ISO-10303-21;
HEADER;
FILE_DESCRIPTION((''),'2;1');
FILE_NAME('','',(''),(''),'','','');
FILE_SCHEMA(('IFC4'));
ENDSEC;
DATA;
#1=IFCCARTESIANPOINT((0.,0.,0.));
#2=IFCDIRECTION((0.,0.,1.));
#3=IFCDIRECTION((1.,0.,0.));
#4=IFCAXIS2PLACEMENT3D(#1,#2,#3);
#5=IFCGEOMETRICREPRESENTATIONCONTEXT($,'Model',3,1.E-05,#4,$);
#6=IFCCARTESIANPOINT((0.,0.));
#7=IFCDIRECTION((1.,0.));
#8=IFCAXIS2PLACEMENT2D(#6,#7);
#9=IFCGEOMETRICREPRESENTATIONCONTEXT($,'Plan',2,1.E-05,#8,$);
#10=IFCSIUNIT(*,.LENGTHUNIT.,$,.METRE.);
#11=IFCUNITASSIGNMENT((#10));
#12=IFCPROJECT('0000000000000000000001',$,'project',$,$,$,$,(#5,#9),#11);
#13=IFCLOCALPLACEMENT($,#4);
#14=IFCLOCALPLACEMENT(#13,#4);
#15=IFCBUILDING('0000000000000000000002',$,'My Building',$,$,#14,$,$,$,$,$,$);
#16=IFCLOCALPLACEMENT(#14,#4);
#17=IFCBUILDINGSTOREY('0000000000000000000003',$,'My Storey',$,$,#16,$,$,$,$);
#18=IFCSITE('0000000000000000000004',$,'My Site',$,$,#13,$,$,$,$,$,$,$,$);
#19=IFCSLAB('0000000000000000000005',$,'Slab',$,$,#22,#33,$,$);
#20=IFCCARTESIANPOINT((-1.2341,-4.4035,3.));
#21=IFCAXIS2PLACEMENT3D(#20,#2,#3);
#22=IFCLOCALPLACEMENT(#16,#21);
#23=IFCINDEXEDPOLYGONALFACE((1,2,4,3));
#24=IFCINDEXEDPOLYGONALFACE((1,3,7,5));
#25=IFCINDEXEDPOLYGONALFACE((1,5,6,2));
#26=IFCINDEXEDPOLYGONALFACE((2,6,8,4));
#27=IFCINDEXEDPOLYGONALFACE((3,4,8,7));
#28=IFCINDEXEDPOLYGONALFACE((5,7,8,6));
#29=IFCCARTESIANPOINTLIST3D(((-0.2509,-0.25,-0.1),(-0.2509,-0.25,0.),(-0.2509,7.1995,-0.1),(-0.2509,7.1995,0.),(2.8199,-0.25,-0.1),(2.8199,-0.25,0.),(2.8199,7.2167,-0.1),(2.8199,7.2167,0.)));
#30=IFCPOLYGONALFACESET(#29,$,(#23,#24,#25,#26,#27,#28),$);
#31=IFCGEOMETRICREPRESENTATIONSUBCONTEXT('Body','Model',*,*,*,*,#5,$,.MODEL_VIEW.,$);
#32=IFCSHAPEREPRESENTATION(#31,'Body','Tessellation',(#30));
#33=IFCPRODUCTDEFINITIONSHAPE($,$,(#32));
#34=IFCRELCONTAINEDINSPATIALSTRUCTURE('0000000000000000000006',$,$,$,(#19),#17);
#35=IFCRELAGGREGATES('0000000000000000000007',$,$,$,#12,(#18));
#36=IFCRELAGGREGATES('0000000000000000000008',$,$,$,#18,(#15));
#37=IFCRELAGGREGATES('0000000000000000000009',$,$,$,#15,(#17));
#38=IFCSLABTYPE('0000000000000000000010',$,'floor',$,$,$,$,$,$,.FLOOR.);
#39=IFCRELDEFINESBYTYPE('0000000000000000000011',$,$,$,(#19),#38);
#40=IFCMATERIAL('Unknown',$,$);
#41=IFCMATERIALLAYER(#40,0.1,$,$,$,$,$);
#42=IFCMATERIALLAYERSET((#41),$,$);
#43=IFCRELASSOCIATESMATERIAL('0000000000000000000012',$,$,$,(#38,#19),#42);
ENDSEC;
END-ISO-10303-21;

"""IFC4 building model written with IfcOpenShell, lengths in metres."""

from ifc_helpers import new_model, si_unit, frame, origin_with_axes, origin_2d_with_axis, place, context, subcontext, project, spatial, indexed_curve, outline, extrude, material, layer, layer_set, layer_usage, type_object, element, save


model = new_model("IFC4")

# Units and contexts
model_context = context("Model", 3, precision=1e-05, world=origin_with_axes())
plan_context = context("Plan", 2, precision=1e-05, world=origin_2d_with_axis())
body_context_1 = subcontext(model_context, "Body", "Model", "MODEL_VIEW")
ifc_project = project(units=[si_unit("LENGTHUNIT", "METRE")], contexts=[model_context, plan_context])

# Site, building, storey
site_placement = place(None, origin_with_axes())
site = spatial("IfcSite", under=ifc_project, at=site_placement, Name="My Site")
building_placement = place(site_placement, origin_with_axes())
building = spatial("IfcBuilding", under=site, at=building_placement, Name="My Building")
storey_placement = place(building_placement, origin_with_axes())
storey = spatial("IfcBuildingStorey", under=building, at=storey_placement, Name="My Storey")

# Shared definitions
ifc_material = material(Name="Unknown")

# Slab
ifc_layer_1 = layer(ifc_material, 0.1)
ifc_layer_set_1 = layer_set([ifc_layer_1])
ifc_layer_usage_1 = layer_usage(ifc_layer_set_1, "AXIS3", "POSITIVE", -0.1)
slab_type = type_object("IfcSlabType", Name="floor", PredefinedType="FLOOR", material=ifc_layer_set_1)
slab_placement = place(storey_placement, frame((-1.2341, -4.4035, 3.0), z_axis=(0.0, 0.0, 1.0), x_axis=(1.0, 0.0, 0.0)))
element("IfcSlab", 1, at=slab_placement, inside=storey, type_object=slab_type, material=ifc_layer_usage_1, Name="Slab", context=body_context_1, shape_type="SweptSolid", body=[
    extrude(outline(indexed_curve([(2.8199, -0.25), (2.8199, 7.2167), (-0.2509, 7.1995), (-0.2509, -0.25), (2.8199, -0.25)])), frame((0.0, 0.0, -0.1), z_axis=(0.0, 0.0, 1.0), x_axis=(1.0, 0.0, 0.0)), (0.0, 0.0, 1.0), 0.1),
])

save(model, "model.ifc")
